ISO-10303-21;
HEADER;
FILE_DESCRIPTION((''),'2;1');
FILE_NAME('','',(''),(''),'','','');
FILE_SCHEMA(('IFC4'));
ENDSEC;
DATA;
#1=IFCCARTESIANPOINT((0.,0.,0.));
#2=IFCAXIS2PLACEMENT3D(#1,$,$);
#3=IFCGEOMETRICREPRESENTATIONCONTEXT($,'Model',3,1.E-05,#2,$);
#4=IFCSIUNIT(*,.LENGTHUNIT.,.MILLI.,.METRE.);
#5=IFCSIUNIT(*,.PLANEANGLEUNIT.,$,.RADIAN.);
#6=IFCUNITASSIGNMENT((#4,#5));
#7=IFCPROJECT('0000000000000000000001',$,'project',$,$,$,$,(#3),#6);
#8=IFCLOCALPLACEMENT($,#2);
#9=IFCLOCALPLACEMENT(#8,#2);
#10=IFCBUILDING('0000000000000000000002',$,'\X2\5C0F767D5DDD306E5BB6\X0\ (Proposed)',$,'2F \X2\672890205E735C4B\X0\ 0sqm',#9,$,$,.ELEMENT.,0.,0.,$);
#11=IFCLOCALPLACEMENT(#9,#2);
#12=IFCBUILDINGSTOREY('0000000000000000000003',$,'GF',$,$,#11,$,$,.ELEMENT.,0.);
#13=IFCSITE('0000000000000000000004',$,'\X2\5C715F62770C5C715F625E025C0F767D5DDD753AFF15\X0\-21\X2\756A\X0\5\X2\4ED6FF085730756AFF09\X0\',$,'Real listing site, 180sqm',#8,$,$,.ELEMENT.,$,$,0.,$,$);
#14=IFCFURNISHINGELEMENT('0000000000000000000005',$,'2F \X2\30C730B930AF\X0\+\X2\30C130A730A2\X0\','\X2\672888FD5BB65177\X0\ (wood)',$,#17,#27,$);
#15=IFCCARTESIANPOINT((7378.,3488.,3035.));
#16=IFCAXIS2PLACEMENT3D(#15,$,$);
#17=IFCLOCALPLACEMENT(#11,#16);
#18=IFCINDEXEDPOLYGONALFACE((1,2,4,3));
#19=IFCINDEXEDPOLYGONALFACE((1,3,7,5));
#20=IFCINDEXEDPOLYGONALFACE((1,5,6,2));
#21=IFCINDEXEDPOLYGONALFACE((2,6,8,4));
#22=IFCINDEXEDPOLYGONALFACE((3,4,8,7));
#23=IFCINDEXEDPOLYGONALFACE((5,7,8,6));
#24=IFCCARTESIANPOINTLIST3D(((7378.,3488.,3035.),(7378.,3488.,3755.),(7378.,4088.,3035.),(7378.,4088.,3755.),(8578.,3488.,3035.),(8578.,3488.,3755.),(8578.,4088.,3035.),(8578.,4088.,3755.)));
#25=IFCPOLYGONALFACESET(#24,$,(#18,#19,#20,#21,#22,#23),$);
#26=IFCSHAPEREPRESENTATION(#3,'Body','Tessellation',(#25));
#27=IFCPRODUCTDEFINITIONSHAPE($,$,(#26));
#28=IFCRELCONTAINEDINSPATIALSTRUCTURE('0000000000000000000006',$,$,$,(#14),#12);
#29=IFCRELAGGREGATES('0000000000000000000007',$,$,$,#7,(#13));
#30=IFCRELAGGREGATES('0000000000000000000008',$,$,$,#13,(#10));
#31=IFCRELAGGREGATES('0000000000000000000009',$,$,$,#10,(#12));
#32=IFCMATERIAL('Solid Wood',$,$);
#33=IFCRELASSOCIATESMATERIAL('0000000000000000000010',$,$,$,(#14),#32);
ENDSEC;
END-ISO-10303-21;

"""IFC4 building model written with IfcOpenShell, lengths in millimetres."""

from ifc_helpers import new_model, si_unit, frame, frame_2d, origin, place, context, project, spatial, rectangle, extrude, material, element, save


model = new_model("IFC4")

# Units and contexts
model_context = context("Model", 3, precision=1e-05, world=origin())
ifc_project = project(units=[si_unit("LENGTHUNIT", "METRE", prefix="MILLI"), si_unit("PLANEANGLEUNIT", "RADIAN")], contexts=[model_context])

# Site, building, storey
site_placement = place(None, origin())
site = spatial("IfcSite", under=ifc_project, at=site_placement, Name="山形県山形市小白川町５-21番5他（地番）", ObjectType="Real listing site, 180sqm", CompositionType="ELEMENT", RefElevation=0.0)
building_placement = place(site_placement, origin())
building = spatial("IfcBuilding", under=site, at=building_placement, Name="小白川の家 (Proposed)", ObjectType="2F 木造平屋 0sqm", CompositionType="ELEMENT", ElevationOfRefHeight=0.0, ElevationOfTerrain=0.0)
storey_placement = place(building_placement, origin())
storey = spatial("IfcBuildingStorey", under=building, at=storey_placement, Name="GF", CompositionType="ELEMENT", Elevation=0.0)

# Shared definitions
ifc_material_1 = material(Name="Solid Wood")

# Furnishing element
furnishing_1_placement = place(storey_placement, frame((7378.0, 3488.0, 3035.0)))
element("IfcFurnishingElement", 1, at=furnishing_1_placement, inside=storey, material=ifc_material_1, Name="2F デスク+チェア", Description="木製家具 (wood)", context=model_context, shape_type="SweptSolid", body=[
    extrude(rectangle(XDim=1200.0, YDim=600.0, at=frame_2d((600.0, 300.0))), frame((7378.0, 3488.0, 3035.0)), (0.0, 0.0, 1.0), 720.0),
])

save(model, "model.ifc")
